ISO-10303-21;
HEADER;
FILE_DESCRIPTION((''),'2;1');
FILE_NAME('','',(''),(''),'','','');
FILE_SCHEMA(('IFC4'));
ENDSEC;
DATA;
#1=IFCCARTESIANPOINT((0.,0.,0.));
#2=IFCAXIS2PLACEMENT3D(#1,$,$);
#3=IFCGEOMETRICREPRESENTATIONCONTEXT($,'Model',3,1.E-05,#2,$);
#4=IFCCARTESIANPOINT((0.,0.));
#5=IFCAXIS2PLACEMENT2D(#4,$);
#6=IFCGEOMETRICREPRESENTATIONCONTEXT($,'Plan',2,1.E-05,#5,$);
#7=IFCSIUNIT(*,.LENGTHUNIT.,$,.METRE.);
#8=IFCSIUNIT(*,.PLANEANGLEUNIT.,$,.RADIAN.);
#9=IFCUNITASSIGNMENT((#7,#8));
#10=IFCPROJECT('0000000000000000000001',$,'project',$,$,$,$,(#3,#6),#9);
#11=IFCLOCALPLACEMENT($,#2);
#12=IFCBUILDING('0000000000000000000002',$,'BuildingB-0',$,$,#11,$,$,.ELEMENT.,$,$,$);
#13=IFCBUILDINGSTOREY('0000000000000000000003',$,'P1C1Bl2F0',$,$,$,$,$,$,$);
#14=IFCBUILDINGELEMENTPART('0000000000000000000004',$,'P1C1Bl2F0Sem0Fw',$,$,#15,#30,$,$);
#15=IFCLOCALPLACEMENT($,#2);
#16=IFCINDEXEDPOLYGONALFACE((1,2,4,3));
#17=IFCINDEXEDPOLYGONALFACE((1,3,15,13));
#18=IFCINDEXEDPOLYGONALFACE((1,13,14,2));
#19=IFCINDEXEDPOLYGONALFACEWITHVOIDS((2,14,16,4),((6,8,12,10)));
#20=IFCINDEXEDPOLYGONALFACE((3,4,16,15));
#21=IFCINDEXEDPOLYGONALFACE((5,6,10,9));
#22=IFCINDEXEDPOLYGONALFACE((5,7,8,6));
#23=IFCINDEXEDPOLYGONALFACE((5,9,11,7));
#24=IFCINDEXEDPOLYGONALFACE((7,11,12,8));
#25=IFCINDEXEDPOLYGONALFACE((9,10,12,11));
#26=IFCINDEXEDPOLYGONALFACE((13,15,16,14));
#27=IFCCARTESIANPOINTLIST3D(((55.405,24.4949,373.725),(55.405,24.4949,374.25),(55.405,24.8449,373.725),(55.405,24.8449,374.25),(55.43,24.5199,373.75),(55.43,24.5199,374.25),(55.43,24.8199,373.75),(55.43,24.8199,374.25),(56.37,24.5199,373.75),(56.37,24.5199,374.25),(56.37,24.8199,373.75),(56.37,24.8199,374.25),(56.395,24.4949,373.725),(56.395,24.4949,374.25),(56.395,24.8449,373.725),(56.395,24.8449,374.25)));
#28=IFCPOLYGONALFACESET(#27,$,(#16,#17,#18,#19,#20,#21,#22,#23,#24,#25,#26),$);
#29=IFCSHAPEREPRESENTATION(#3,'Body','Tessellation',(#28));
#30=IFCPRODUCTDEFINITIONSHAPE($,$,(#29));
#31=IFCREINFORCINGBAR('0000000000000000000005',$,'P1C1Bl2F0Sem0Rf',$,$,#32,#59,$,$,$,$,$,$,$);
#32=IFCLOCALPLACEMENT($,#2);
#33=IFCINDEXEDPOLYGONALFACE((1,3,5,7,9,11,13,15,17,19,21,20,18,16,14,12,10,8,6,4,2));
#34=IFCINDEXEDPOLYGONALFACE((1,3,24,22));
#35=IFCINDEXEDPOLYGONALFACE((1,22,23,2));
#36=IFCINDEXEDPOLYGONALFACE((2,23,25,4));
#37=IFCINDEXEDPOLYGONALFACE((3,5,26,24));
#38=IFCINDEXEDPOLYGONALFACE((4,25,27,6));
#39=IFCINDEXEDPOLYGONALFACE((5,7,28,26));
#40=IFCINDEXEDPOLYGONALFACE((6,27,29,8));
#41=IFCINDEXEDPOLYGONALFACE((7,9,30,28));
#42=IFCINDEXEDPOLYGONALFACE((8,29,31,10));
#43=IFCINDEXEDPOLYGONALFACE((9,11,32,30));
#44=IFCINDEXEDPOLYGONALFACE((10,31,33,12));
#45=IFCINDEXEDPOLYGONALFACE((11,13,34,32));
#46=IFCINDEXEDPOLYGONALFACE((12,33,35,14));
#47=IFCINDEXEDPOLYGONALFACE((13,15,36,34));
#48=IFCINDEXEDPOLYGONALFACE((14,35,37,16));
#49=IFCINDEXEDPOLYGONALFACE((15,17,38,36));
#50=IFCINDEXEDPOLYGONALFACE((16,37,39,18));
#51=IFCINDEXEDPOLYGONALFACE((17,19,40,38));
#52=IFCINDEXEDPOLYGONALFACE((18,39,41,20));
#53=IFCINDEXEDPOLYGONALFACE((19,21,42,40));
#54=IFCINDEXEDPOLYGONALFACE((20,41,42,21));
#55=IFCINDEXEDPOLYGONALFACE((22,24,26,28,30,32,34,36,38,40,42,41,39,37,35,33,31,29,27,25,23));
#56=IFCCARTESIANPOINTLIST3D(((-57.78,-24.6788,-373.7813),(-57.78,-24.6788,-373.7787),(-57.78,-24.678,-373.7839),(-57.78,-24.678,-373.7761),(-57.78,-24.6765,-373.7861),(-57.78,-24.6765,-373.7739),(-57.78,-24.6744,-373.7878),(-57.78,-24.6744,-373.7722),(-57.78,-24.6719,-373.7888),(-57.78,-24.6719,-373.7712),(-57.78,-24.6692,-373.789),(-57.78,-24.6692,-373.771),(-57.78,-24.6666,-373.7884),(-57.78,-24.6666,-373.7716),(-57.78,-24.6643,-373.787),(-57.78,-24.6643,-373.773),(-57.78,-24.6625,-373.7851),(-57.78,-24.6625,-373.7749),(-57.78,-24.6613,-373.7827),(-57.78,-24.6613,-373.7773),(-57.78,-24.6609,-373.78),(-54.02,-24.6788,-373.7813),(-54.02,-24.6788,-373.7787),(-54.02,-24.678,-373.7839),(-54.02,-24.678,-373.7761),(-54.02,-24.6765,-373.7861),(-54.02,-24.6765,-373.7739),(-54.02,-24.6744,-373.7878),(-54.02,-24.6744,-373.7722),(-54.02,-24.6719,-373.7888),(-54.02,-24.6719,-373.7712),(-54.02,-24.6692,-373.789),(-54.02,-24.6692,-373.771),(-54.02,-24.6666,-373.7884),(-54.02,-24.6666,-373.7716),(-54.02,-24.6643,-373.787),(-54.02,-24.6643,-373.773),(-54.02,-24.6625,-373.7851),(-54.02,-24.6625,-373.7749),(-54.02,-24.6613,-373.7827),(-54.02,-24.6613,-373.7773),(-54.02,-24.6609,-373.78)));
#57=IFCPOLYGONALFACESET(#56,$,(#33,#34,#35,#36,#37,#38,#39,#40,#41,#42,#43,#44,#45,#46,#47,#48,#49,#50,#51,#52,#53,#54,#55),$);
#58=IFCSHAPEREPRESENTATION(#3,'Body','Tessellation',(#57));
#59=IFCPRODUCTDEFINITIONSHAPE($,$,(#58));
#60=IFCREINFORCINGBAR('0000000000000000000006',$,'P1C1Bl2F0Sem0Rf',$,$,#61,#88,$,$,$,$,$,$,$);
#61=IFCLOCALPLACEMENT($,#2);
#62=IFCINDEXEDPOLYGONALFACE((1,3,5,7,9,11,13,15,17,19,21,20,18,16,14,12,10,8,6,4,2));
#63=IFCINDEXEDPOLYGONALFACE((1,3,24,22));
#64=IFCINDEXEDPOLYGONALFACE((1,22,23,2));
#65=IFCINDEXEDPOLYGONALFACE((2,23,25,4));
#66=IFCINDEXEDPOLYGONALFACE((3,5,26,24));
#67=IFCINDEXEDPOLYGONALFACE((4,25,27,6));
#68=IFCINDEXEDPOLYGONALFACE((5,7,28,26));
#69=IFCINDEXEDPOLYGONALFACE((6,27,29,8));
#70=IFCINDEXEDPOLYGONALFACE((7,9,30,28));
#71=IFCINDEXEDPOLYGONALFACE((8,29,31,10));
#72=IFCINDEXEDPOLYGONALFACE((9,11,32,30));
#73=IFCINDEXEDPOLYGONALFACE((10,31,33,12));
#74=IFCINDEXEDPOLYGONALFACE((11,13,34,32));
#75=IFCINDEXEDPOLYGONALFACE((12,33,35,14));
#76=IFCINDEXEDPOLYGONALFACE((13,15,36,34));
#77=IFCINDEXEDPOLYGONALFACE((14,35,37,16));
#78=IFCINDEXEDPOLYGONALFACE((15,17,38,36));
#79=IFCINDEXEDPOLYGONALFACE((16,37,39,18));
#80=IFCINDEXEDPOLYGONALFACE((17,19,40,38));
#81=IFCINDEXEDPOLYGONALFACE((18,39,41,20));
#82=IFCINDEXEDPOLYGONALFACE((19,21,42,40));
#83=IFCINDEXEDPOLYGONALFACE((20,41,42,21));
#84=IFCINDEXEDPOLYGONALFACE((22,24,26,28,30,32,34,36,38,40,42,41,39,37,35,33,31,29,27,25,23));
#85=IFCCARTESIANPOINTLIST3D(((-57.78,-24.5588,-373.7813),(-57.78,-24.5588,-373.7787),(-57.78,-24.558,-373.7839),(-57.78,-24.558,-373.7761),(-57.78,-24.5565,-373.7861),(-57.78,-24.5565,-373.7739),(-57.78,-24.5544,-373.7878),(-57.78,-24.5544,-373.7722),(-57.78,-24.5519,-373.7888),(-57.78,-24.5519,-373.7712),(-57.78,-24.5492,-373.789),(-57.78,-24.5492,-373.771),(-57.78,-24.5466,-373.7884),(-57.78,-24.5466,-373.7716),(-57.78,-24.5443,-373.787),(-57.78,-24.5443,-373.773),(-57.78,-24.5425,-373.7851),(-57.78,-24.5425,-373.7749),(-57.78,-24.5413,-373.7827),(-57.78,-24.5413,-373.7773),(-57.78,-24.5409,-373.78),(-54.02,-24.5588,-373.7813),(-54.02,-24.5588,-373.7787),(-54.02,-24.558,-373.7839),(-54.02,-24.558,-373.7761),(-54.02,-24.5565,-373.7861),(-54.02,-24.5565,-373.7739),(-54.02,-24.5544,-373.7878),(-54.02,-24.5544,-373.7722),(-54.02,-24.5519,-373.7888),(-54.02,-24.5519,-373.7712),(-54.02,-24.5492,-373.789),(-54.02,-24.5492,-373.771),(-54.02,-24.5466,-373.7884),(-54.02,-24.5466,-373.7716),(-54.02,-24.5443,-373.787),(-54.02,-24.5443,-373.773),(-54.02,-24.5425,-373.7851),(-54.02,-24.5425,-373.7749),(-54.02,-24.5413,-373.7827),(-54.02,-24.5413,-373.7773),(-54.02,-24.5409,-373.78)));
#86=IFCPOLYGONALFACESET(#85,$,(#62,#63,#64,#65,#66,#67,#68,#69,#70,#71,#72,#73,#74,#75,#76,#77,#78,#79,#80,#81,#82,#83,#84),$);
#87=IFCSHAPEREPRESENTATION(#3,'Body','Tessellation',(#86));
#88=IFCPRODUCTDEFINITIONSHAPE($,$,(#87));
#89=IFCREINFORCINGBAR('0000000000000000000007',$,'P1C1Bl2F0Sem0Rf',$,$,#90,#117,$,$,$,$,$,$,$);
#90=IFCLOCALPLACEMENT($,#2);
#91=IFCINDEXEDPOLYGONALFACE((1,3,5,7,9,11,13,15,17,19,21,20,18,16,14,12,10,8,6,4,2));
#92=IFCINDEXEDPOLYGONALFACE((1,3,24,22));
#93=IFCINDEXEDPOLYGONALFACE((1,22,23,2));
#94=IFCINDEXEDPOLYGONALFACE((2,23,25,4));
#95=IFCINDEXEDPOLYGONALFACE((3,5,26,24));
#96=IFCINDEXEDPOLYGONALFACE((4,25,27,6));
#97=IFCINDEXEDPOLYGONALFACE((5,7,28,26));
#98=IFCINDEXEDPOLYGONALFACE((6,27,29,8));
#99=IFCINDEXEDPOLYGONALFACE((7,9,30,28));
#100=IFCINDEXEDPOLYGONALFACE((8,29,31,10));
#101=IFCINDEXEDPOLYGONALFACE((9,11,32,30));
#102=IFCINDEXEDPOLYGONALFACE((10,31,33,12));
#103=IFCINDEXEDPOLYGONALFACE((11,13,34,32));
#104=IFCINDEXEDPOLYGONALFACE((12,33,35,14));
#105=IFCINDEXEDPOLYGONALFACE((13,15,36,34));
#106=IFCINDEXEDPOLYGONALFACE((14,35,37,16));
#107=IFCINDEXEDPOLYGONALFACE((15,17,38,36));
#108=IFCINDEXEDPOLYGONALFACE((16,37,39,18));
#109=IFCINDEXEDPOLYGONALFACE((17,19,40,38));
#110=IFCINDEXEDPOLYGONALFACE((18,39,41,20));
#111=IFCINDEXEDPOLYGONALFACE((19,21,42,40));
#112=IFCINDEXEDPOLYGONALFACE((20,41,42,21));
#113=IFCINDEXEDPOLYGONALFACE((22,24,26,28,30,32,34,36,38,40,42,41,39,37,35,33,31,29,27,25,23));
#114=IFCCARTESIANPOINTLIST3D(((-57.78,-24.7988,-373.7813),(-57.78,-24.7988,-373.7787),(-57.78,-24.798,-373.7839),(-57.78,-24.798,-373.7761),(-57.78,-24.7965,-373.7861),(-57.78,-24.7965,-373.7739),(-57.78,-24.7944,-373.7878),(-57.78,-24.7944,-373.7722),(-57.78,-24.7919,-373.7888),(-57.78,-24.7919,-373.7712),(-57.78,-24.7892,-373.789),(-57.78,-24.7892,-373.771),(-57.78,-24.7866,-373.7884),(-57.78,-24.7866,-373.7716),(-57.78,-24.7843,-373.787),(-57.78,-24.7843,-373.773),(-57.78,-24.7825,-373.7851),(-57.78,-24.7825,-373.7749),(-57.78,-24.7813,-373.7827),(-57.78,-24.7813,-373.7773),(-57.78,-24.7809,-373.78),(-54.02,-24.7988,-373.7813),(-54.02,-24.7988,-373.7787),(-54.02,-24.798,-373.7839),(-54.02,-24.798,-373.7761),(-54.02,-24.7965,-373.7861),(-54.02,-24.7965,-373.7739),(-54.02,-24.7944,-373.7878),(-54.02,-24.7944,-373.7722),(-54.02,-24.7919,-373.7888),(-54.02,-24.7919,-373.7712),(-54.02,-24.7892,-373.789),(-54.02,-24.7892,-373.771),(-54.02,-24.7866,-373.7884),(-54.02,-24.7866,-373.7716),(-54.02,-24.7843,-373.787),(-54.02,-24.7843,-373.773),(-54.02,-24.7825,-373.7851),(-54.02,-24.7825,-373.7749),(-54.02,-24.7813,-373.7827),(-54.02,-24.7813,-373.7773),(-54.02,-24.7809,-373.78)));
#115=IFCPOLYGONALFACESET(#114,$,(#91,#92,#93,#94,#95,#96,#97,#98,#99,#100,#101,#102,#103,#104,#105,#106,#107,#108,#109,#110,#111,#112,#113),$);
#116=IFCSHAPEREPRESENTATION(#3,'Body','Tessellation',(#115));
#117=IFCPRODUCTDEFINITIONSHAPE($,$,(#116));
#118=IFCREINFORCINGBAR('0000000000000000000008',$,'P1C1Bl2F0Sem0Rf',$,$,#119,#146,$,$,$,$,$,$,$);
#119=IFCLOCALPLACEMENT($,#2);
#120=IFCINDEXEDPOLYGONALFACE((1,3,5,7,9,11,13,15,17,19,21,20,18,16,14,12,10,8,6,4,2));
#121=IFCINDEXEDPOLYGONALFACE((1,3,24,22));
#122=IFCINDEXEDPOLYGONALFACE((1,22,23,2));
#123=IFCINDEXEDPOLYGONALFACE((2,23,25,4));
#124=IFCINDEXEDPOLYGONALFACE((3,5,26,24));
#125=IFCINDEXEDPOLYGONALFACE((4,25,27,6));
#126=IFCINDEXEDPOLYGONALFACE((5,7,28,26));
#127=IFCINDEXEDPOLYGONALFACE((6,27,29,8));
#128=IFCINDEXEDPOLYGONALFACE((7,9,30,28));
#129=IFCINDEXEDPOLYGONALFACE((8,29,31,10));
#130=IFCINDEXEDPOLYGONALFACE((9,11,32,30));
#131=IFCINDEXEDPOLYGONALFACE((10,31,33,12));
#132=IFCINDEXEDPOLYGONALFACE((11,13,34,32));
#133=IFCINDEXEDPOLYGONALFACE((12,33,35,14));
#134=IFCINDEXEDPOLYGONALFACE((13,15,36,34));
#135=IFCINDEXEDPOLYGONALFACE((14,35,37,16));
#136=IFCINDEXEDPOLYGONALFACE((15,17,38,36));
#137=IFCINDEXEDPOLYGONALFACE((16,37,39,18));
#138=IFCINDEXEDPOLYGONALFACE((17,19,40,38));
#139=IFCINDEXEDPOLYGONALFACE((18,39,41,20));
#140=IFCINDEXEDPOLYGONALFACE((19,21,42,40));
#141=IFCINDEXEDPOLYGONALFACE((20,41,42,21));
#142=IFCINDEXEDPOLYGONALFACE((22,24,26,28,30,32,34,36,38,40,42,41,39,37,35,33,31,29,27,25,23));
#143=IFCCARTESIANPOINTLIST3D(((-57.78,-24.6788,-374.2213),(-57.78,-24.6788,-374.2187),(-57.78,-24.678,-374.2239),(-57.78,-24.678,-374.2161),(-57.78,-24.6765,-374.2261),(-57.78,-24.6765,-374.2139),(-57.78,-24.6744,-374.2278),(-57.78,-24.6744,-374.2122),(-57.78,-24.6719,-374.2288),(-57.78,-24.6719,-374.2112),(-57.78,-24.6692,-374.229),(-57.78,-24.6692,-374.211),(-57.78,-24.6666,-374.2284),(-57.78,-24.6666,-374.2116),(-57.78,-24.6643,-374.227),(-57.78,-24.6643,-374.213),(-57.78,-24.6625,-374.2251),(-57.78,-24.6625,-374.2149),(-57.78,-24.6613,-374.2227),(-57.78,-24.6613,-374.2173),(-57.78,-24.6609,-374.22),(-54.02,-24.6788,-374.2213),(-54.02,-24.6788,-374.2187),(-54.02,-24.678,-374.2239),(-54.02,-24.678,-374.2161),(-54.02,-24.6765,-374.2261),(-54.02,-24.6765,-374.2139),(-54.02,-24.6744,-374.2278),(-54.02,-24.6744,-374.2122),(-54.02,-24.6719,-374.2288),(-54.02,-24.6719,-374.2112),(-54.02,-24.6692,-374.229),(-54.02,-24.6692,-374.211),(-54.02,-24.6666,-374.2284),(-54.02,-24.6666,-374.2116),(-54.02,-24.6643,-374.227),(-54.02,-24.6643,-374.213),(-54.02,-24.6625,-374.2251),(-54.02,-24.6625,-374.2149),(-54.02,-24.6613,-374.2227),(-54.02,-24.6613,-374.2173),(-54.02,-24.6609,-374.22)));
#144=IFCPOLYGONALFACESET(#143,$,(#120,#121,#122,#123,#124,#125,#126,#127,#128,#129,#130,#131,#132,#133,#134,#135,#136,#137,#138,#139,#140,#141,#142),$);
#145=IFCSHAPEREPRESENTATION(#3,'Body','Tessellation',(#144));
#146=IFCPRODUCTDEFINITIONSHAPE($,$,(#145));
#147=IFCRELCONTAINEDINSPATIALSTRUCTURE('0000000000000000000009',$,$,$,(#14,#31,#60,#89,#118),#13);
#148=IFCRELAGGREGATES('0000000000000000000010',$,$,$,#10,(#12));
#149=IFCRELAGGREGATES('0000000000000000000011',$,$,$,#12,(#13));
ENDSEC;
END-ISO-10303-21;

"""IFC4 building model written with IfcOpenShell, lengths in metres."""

from ifc_helpers import new_model, entity, si_unit, origin, origin_2d, place, context, project, spatial, polyline, outline, extrude, element, save


model = new_model("IFC4")

# Units and contexts
model_context = context("Model", 3, precision=1e-05, world=origin())
plan_context = context("Plan", 2, precision=1e-05, world=origin_2d())
ifc_project = project(units=[si_unit("LENGTHUNIT", "METRE"), si_unit("PLANEANGLEUNIT", "RADIAN")], contexts=[model_context, plan_context])

# Building, storey
building_placement = place(None, origin())
building = spatial("IfcBuilding", under=ifc_project, at=building_placement, Name="BuildingB-0", CompositionType="ELEMENT")
storey = spatial("IfcBuildingStorey", under=building, Name="P1C1Bl2F0")

# Building element part, opening
building_element_part_1 = element("IfcBuildingElementPart", 1, inside=storey, Name="P1C1Bl2F0Sem0Fw", context=model_context, shape_type="SweptSolid", body=[
    extrude(outline(polyline([(55.405, 24.4949, 373.725), (55.405, 24.8449, 373.725), (56.395, 24.8449, 373.725), (56.395, 24.4949, 373.725), (55.405, 24.4949, 373.725)])), None, (0.0, 0.0, 1.0), 0.525),
])
element("IfcOpeningElement", 2, inside=storey, cuts=building_element_part_1, context=model_context, shape_type="SweptSolid", body=[
    extrude(outline(polyline([(55.43, 24.5199, 373.75), (55.43, 24.8199, 373.75), (56.37, 24.8199, 373.75), (56.37, 24.5199, 373.75), (55.43, 24.5199, 373.75)])), None, (0.0, 0.0, 1.0), 0.5),
])

# Reinforcing bars
element("IfcReinforcingBar", 3, inside=storey, Name="P1C1Bl2F0Sem0Rf", context=model_context, shape_type="SweptSolid", body=[
    entity("IfcSurfaceCurveSweptAreaSolid", entity("IfcCircleProfileDef", "AREA", None, None, 0.009), None, entity("IfcPolyline", [entity("IfcCartesianPoint", [54.02, 24.6699, 373.78]), entity("IfcCartesianPoint", [57.78, 24.6699, 373.78])]), None, None, entity("IfcPlane", entity("IfcAxis2Placement3D", entity("IfcCartesianPoint", [54.02, 24.6699, 373.78]), entity("IfcDirection", [0.0, 0.0, 1.0]), entity("IfcDirection", [1.0, 0.0, 0.0])))),
])
element("IfcReinforcingBar", 4, inside=storey, Name="P1C1Bl2F0Sem0Rf", context=model_context, shape_type="SweptSolid", body=[
    entity("IfcSurfaceCurveSweptAreaSolid", entity("IfcCircleProfileDef", "AREA", None, None, 0.009), None, entity("IfcPolyline", [entity("IfcCartesianPoint", [54.02, 24.5499, 373.78]), entity("IfcCartesianPoint", [57.78, 24.5499, 373.78])]), None, None, entity("IfcPlane", entity("IfcAxis2Placement3D", entity("IfcCartesianPoint", [54.02, 24.5499, 373.78]), entity("IfcDirection", [0.0, 0.0, 1.0]), entity("IfcDirection", [1.0, 0.0, 0.0])))),
])
element("IfcReinforcingBar", 5, inside=storey, Name="P1C1Bl2F0Sem0Rf", context=model_context, shape_type="SweptSolid", body=[
    entity("IfcSurfaceCurveSweptAreaSolid", entity("IfcCircleProfileDef", "AREA", None, None, 0.009), None, entity("IfcPolyline", [entity("IfcCartesianPoint", [54.02, 24.7899, 373.78]), entity("IfcCartesianPoint", [57.78, 24.7899, 373.78])]), None, None, entity("IfcPlane", entity("IfcAxis2Placement3D", entity("IfcCartesianPoint", [54.02, 24.7899, 373.78]), entity("IfcDirection", [0.0, 0.0, 1.0]), entity("IfcDirection", [1.0, 0.0, 0.0])))),
])
element("IfcReinforcingBar", 6, inside=storey, Name="P1C1Bl2F0Sem0Rf", context=model_context, shape_type="SweptSolid", body=[
    entity("IfcSurfaceCurveSweptAreaSolid", entity("IfcCircleProfileDef", "AREA", None, None, 0.009), None, entity("IfcPolyline", [entity("IfcCartesianPoint", [54.02, 24.6699, 374.22]), entity("IfcCartesianPoint", [57.78, 24.6699, 374.22])]), None, None, entity("IfcPlane", entity("IfcAxis2Placement3D", entity("IfcCartesianPoint", [54.02, 24.6699, 374.22]), entity("IfcDirection", [0.0, 0.0, 1.0]), entity("IfcDirection", [1.0, 0.0, 0.0])))),
])

save(model, "model.ifc")
